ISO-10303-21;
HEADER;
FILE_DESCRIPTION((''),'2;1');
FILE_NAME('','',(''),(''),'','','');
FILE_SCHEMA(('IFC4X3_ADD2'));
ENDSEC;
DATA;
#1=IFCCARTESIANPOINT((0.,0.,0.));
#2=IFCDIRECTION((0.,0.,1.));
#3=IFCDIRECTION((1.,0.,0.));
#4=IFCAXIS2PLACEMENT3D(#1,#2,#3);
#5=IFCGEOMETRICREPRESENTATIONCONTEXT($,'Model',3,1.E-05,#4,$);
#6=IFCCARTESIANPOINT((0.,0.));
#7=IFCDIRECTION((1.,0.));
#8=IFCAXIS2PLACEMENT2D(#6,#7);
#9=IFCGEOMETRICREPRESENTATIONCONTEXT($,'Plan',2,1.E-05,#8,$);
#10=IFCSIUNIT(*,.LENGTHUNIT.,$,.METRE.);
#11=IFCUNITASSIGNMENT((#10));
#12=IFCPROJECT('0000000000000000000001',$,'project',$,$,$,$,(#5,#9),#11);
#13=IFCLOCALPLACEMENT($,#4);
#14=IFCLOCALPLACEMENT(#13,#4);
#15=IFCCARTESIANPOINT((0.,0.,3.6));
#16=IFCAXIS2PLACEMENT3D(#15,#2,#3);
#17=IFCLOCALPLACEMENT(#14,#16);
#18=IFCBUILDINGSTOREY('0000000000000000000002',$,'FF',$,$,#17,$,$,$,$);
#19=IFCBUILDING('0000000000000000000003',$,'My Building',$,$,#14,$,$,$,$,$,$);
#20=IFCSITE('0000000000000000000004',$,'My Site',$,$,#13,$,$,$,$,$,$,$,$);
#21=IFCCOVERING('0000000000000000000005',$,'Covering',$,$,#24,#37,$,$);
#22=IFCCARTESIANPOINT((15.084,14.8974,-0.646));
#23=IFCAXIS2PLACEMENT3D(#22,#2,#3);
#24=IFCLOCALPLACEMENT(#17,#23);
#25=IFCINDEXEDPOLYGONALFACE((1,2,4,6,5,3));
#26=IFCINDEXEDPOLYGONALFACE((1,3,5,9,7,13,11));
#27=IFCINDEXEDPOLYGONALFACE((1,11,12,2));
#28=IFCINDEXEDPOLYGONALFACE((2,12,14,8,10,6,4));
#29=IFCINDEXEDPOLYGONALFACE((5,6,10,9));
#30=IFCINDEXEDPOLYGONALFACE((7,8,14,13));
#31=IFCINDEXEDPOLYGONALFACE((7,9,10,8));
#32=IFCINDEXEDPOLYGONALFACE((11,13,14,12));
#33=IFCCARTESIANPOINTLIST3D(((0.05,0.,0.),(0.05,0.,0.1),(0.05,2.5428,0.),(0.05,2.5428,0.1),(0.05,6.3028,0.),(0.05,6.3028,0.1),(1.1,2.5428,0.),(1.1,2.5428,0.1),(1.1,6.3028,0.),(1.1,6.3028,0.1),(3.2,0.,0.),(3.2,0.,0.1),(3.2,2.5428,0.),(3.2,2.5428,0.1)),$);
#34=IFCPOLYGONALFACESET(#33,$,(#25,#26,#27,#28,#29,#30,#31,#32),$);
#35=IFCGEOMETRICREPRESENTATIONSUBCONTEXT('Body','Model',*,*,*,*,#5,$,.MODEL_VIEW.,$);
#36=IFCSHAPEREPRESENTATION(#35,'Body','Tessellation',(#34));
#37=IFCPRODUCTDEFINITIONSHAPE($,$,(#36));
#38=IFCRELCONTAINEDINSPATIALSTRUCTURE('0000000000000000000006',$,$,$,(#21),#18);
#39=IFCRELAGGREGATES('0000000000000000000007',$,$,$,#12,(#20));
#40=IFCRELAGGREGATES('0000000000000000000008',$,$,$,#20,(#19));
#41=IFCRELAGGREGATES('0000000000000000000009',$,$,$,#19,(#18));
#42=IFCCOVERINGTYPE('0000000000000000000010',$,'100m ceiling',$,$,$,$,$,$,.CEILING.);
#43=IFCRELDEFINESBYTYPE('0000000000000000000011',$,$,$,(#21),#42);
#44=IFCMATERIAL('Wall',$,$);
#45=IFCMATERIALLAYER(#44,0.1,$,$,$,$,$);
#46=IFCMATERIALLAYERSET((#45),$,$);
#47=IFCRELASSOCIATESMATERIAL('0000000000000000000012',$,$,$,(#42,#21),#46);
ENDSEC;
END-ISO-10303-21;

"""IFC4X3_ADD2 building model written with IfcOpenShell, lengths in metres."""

from ifc_helpers import new_model, si_unit, frame, origin_with_axes, origin_2d_with_axis, place, context, subcontext, project, spatial, line, indexed_curve, outline, extrude, material, layer, layer_set, layer_usage, type_object, element, save


model = new_model("IFC4X3_ADD2")

# Units and contexts
model_context = context("Model", 3, precision=1e-05, world=origin_with_axes())
plan_context = context("Plan", 2, precision=1e-05, world=origin_2d_with_axis())
body_context = subcontext(model_context, "Body", "Model", "MODEL_VIEW")
ifc_project = project(units=[si_unit("LENGTHUNIT", "METRE")], contexts=[model_context, plan_context])

# Site, building, storey
site_placement = place(None, origin_with_axes())
site = spatial("IfcSite", under=ifc_project, at=site_placement, Name="My Site")
building_placement = place(site_placement, origin_with_axes())
building = spatial("IfcBuilding", under=site, at=building_placement, Name="My Building")
storey_placement = place(building_placement, frame((0.0, 0.0, 3.6), z_axis=(0.0, 0.0, 1.0), x_axis=(1.0, 0.0, 0.0)))
storey = spatial("IfcBuildingStorey", under=building, at=storey_placement, Name="FF")

# Covering
ifc_material_1 = material(Name="Wall")
ifc_layer_1 = layer(ifc_material_1, 0.1)
ifc_layer_set_1 = layer_set([ifc_layer_1])
ifc_layer_usage_1 = layer_usage(ifc_layer_set_1, "AXIS3", "POSITIVE", 0.0)
covering_type = type_object("IfcCoveringType", Name="100m ceiling", PredefinedType="CEILING", material=ifc_layer_set_1)
covering_placement = place(storey_placement, frame((15.084, 14.8974, -0.646), z_axis=(0.0, 0.0, 1.0), x_axis=(1.0, 0.0, 0.0)))
element("IfcCovering", 1, at=covering_placement, inside=storey, type_object=covering_type, material=ifc_layer_usage_1, Name="Covering", context=body_context, shape_type="SweptSolid", body=[
    extrude(outline(indexed_curve([(0.05, 6.3028), (0.05, 2.5428), (0.05, 0.0), (3.2, 0.0), (3.2, 2.5428), (1.1, 2.5428), (1.1, 6.3028)], segments=[line(4, 3), line(3, 2), line(2, 1), line(1, 7), line(7, 6), line(6, 5), line(5, 4)], self_intersect=False)), None, (0.0, 0.0, 1.0), 0.1),
])

save(model, "model.ifc")
